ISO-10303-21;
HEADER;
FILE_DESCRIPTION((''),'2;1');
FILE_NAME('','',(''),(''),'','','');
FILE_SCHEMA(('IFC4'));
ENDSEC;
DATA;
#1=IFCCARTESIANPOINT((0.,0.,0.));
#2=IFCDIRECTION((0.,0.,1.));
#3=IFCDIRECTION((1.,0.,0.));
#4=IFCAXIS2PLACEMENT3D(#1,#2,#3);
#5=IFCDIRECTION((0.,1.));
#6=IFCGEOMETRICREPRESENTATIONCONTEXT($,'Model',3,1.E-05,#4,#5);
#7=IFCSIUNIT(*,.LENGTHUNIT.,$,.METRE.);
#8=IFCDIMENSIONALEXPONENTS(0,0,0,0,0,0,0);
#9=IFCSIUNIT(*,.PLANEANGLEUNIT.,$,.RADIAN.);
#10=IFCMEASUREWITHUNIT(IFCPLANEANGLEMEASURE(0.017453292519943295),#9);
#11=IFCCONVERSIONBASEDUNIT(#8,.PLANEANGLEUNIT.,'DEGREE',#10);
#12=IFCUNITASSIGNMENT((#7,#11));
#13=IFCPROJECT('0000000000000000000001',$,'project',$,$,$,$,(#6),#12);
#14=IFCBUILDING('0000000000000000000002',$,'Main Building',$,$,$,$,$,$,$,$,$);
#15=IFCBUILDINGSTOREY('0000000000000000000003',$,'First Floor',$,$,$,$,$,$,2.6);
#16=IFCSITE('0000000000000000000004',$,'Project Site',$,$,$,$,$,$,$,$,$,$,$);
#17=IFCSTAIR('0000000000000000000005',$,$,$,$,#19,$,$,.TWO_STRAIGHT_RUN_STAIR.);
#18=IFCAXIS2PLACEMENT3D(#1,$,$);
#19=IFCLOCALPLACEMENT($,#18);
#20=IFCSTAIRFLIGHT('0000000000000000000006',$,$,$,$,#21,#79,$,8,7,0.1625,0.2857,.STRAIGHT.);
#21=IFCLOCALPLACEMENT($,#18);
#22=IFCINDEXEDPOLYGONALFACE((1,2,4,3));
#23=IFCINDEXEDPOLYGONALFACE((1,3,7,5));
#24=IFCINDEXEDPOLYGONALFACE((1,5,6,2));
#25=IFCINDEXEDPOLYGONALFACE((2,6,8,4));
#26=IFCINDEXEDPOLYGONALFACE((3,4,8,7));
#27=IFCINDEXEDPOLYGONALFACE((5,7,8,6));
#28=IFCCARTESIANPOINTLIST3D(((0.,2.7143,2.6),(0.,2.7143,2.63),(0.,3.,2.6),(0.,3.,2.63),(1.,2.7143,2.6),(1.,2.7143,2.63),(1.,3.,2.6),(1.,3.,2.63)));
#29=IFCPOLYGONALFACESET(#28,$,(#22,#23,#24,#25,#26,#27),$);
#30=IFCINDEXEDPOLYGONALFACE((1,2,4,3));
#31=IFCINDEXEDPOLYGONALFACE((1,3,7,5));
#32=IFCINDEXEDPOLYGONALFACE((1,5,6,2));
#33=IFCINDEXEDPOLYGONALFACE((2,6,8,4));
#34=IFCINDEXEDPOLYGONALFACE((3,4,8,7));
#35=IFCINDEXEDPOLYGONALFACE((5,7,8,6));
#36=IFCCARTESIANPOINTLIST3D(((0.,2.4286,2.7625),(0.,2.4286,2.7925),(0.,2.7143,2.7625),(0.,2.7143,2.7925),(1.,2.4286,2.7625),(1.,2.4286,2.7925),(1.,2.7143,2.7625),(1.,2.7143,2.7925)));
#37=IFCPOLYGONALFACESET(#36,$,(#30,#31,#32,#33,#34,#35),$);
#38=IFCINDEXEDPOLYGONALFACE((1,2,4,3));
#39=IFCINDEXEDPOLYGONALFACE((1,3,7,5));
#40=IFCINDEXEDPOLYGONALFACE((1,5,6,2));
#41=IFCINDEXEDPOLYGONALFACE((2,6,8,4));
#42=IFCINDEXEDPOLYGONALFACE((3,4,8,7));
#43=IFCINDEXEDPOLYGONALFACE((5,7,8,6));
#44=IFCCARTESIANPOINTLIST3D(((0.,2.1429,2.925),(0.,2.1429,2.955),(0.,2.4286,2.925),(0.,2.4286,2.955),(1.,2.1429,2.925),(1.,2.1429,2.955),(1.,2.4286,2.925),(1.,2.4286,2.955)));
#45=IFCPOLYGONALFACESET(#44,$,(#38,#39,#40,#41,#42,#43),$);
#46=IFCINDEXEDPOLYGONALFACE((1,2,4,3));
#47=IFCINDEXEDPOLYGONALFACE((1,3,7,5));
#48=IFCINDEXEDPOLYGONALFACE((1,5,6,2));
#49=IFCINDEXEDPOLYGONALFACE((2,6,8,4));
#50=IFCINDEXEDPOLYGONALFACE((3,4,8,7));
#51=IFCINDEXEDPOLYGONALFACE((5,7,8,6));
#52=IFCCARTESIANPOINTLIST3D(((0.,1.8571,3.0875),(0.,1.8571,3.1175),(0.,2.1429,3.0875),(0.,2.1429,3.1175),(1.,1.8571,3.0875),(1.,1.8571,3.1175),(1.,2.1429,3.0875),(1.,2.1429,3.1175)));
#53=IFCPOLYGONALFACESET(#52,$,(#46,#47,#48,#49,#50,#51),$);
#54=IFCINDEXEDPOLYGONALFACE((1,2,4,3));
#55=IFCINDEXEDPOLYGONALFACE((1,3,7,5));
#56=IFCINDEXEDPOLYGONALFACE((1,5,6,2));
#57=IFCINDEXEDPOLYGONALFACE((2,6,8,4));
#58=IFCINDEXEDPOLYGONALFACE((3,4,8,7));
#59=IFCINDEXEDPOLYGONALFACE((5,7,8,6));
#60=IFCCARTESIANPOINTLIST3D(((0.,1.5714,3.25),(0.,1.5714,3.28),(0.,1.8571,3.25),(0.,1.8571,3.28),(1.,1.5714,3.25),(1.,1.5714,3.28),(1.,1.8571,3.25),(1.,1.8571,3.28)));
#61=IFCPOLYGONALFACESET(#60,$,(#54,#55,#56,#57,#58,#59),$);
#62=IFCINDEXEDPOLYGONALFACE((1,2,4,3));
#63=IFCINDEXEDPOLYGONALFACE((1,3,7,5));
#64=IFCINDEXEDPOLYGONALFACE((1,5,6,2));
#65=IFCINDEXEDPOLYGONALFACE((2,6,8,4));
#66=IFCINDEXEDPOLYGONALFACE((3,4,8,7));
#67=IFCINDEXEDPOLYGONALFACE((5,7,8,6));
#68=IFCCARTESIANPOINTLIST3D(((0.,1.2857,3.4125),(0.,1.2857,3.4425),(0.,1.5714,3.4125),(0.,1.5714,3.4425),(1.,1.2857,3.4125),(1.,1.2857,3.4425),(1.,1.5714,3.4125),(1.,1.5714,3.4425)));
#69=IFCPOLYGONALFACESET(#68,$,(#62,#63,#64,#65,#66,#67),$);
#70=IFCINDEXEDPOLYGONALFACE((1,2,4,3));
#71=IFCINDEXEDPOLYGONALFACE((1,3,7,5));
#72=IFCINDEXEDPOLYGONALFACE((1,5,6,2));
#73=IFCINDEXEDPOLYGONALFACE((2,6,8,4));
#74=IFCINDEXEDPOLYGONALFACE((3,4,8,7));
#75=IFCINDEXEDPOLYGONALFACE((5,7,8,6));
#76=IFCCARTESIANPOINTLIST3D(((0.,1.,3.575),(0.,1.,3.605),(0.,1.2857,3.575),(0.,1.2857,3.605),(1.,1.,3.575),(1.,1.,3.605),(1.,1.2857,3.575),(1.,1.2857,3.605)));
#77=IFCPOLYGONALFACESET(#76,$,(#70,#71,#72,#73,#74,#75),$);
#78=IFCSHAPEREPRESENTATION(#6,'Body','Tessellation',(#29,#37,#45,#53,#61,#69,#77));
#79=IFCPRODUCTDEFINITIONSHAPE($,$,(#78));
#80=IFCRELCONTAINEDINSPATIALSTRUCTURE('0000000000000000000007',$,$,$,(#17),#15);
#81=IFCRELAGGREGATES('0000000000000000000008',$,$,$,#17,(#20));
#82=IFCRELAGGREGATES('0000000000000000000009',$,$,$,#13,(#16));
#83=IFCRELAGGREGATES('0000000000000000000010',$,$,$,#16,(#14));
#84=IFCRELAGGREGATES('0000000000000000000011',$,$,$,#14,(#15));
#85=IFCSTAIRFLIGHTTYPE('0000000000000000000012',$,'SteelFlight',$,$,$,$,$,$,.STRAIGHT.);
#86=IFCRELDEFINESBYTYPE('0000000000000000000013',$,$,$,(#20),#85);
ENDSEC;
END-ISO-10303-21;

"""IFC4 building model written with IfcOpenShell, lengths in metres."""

from ifc_helpers import new_model, entity, si_unit, converted_unit, direction, frame, frame_2d, origin, origin_with_axes, place, context, project, spatial, rectangle, extrude, type_object, element, aggregate, save


model = new_model("IFC4")

# Units and contexts
model_context = context("Model", 3, precision=1e-05, world=origin_with_axes(), true_north=direction((0.0, 1.0)))
ifc_project = project(units=[si_unit("LENGTHUNIT", "METRE"), converted_unit("PLANEANGLEUNIT", "DEGREE", entity("IfcPlaneAngleMeasure", 0.017453292519943295), si_unit("PLANEANGLEUNIT", "RADIAN"), dimensions=[0, 0, 0, 0, 0, 0, 0])], contexts=[model_context])

# Site, building, storey
site = spatial("IfcSite", under=ifc_project, Name="Project Site")
building = spatial("IfcBuilding", under=site, Name="Main Building")
storey = spatial("IfcBuildingStorey", under=building, Name="First Floor", Elevation=2.6)

# Stair, stair flight
stair_placement = place(None, origin_with_axes())
stair = element("IfcStair", 1, at=stair_placement, inside=storey, PredefinedType="TWO_STRAIGHT_RUN_STAIR")
stair_flight_type = type_object("IfcStairFlightType", Name="SteelFlight", PredefinedType="STRAIGHT")
stair_flight_placement = place(stair_placement, frame((0.5, 3.0, 2.6), z_axis=(0.0, 0.0, 1.0), x_axis=(0.0, -1.0, 0.0)))
stair_flight = element("IfcStairFlight", 2, at=stair_flight_placement, type_object=stair_flight_type, NumberOfRisers=8, NumberOfTreads=7, PredefinedType="STRAIGHT", RiserHeight=0.1625, TreadLength=0.2857, context=model_context, shape_type="SweptSolid", body=[
    extrude(rectangle(XDim=0.2857, YDim=1.0, at=frame_2d((0.1429, 0.0))), origin(), (0.0, 0.0, 1.0), 0.03),
    extrude(rectangle(XDim=0.2857, YDim=1.0, at=frame_2d((0.1429, 0.0))), frame((0.2857, 0.0, 0.1625)), (0.0, 0.0, 1.0), 0.03),
    extrude(rectangle(XDim=0.2857, YDim=1.0, at=frame_2d((0.1429, 0.0))), frame((0.5714, 0.0, 0.325)), (0.0, 0.0, 1.0), 0.03),
    extrude(rectangle(XDim=0.2857, YDim=1.0, at=frame_2d((0.1429, 0.0))), frame((0.8571, 0.0, 0.4875)), (0.0, 0.0, 1.0), 0.03),
    extrude(rectangle(XDim=0.2857, YDim=1.0, at=frame_2d((0.1429, 0.0))), frame((1.1429, 0.0, 0.65)), (0.0, 0.0, 1.0), 0.03),
    extrude(rectangle(XDim=0.2857, YDim=1.0, at=frame_2d((0.1429, 0.0))), frame((1.4286, 0.0, 0.8125)), (0.0, 0.0, 1.0), 0.03),
    extrude(rectangle(XDim=0.2857, YDim=1.0, at=frame_2d((0.1429, 0.0))), frame((1.7143, 0.0, 0.975)), (0.0, 0.0, 1.0), 0.03),
])
aggregate(stair, [stair_flight])

save(model, "model.ifc")
